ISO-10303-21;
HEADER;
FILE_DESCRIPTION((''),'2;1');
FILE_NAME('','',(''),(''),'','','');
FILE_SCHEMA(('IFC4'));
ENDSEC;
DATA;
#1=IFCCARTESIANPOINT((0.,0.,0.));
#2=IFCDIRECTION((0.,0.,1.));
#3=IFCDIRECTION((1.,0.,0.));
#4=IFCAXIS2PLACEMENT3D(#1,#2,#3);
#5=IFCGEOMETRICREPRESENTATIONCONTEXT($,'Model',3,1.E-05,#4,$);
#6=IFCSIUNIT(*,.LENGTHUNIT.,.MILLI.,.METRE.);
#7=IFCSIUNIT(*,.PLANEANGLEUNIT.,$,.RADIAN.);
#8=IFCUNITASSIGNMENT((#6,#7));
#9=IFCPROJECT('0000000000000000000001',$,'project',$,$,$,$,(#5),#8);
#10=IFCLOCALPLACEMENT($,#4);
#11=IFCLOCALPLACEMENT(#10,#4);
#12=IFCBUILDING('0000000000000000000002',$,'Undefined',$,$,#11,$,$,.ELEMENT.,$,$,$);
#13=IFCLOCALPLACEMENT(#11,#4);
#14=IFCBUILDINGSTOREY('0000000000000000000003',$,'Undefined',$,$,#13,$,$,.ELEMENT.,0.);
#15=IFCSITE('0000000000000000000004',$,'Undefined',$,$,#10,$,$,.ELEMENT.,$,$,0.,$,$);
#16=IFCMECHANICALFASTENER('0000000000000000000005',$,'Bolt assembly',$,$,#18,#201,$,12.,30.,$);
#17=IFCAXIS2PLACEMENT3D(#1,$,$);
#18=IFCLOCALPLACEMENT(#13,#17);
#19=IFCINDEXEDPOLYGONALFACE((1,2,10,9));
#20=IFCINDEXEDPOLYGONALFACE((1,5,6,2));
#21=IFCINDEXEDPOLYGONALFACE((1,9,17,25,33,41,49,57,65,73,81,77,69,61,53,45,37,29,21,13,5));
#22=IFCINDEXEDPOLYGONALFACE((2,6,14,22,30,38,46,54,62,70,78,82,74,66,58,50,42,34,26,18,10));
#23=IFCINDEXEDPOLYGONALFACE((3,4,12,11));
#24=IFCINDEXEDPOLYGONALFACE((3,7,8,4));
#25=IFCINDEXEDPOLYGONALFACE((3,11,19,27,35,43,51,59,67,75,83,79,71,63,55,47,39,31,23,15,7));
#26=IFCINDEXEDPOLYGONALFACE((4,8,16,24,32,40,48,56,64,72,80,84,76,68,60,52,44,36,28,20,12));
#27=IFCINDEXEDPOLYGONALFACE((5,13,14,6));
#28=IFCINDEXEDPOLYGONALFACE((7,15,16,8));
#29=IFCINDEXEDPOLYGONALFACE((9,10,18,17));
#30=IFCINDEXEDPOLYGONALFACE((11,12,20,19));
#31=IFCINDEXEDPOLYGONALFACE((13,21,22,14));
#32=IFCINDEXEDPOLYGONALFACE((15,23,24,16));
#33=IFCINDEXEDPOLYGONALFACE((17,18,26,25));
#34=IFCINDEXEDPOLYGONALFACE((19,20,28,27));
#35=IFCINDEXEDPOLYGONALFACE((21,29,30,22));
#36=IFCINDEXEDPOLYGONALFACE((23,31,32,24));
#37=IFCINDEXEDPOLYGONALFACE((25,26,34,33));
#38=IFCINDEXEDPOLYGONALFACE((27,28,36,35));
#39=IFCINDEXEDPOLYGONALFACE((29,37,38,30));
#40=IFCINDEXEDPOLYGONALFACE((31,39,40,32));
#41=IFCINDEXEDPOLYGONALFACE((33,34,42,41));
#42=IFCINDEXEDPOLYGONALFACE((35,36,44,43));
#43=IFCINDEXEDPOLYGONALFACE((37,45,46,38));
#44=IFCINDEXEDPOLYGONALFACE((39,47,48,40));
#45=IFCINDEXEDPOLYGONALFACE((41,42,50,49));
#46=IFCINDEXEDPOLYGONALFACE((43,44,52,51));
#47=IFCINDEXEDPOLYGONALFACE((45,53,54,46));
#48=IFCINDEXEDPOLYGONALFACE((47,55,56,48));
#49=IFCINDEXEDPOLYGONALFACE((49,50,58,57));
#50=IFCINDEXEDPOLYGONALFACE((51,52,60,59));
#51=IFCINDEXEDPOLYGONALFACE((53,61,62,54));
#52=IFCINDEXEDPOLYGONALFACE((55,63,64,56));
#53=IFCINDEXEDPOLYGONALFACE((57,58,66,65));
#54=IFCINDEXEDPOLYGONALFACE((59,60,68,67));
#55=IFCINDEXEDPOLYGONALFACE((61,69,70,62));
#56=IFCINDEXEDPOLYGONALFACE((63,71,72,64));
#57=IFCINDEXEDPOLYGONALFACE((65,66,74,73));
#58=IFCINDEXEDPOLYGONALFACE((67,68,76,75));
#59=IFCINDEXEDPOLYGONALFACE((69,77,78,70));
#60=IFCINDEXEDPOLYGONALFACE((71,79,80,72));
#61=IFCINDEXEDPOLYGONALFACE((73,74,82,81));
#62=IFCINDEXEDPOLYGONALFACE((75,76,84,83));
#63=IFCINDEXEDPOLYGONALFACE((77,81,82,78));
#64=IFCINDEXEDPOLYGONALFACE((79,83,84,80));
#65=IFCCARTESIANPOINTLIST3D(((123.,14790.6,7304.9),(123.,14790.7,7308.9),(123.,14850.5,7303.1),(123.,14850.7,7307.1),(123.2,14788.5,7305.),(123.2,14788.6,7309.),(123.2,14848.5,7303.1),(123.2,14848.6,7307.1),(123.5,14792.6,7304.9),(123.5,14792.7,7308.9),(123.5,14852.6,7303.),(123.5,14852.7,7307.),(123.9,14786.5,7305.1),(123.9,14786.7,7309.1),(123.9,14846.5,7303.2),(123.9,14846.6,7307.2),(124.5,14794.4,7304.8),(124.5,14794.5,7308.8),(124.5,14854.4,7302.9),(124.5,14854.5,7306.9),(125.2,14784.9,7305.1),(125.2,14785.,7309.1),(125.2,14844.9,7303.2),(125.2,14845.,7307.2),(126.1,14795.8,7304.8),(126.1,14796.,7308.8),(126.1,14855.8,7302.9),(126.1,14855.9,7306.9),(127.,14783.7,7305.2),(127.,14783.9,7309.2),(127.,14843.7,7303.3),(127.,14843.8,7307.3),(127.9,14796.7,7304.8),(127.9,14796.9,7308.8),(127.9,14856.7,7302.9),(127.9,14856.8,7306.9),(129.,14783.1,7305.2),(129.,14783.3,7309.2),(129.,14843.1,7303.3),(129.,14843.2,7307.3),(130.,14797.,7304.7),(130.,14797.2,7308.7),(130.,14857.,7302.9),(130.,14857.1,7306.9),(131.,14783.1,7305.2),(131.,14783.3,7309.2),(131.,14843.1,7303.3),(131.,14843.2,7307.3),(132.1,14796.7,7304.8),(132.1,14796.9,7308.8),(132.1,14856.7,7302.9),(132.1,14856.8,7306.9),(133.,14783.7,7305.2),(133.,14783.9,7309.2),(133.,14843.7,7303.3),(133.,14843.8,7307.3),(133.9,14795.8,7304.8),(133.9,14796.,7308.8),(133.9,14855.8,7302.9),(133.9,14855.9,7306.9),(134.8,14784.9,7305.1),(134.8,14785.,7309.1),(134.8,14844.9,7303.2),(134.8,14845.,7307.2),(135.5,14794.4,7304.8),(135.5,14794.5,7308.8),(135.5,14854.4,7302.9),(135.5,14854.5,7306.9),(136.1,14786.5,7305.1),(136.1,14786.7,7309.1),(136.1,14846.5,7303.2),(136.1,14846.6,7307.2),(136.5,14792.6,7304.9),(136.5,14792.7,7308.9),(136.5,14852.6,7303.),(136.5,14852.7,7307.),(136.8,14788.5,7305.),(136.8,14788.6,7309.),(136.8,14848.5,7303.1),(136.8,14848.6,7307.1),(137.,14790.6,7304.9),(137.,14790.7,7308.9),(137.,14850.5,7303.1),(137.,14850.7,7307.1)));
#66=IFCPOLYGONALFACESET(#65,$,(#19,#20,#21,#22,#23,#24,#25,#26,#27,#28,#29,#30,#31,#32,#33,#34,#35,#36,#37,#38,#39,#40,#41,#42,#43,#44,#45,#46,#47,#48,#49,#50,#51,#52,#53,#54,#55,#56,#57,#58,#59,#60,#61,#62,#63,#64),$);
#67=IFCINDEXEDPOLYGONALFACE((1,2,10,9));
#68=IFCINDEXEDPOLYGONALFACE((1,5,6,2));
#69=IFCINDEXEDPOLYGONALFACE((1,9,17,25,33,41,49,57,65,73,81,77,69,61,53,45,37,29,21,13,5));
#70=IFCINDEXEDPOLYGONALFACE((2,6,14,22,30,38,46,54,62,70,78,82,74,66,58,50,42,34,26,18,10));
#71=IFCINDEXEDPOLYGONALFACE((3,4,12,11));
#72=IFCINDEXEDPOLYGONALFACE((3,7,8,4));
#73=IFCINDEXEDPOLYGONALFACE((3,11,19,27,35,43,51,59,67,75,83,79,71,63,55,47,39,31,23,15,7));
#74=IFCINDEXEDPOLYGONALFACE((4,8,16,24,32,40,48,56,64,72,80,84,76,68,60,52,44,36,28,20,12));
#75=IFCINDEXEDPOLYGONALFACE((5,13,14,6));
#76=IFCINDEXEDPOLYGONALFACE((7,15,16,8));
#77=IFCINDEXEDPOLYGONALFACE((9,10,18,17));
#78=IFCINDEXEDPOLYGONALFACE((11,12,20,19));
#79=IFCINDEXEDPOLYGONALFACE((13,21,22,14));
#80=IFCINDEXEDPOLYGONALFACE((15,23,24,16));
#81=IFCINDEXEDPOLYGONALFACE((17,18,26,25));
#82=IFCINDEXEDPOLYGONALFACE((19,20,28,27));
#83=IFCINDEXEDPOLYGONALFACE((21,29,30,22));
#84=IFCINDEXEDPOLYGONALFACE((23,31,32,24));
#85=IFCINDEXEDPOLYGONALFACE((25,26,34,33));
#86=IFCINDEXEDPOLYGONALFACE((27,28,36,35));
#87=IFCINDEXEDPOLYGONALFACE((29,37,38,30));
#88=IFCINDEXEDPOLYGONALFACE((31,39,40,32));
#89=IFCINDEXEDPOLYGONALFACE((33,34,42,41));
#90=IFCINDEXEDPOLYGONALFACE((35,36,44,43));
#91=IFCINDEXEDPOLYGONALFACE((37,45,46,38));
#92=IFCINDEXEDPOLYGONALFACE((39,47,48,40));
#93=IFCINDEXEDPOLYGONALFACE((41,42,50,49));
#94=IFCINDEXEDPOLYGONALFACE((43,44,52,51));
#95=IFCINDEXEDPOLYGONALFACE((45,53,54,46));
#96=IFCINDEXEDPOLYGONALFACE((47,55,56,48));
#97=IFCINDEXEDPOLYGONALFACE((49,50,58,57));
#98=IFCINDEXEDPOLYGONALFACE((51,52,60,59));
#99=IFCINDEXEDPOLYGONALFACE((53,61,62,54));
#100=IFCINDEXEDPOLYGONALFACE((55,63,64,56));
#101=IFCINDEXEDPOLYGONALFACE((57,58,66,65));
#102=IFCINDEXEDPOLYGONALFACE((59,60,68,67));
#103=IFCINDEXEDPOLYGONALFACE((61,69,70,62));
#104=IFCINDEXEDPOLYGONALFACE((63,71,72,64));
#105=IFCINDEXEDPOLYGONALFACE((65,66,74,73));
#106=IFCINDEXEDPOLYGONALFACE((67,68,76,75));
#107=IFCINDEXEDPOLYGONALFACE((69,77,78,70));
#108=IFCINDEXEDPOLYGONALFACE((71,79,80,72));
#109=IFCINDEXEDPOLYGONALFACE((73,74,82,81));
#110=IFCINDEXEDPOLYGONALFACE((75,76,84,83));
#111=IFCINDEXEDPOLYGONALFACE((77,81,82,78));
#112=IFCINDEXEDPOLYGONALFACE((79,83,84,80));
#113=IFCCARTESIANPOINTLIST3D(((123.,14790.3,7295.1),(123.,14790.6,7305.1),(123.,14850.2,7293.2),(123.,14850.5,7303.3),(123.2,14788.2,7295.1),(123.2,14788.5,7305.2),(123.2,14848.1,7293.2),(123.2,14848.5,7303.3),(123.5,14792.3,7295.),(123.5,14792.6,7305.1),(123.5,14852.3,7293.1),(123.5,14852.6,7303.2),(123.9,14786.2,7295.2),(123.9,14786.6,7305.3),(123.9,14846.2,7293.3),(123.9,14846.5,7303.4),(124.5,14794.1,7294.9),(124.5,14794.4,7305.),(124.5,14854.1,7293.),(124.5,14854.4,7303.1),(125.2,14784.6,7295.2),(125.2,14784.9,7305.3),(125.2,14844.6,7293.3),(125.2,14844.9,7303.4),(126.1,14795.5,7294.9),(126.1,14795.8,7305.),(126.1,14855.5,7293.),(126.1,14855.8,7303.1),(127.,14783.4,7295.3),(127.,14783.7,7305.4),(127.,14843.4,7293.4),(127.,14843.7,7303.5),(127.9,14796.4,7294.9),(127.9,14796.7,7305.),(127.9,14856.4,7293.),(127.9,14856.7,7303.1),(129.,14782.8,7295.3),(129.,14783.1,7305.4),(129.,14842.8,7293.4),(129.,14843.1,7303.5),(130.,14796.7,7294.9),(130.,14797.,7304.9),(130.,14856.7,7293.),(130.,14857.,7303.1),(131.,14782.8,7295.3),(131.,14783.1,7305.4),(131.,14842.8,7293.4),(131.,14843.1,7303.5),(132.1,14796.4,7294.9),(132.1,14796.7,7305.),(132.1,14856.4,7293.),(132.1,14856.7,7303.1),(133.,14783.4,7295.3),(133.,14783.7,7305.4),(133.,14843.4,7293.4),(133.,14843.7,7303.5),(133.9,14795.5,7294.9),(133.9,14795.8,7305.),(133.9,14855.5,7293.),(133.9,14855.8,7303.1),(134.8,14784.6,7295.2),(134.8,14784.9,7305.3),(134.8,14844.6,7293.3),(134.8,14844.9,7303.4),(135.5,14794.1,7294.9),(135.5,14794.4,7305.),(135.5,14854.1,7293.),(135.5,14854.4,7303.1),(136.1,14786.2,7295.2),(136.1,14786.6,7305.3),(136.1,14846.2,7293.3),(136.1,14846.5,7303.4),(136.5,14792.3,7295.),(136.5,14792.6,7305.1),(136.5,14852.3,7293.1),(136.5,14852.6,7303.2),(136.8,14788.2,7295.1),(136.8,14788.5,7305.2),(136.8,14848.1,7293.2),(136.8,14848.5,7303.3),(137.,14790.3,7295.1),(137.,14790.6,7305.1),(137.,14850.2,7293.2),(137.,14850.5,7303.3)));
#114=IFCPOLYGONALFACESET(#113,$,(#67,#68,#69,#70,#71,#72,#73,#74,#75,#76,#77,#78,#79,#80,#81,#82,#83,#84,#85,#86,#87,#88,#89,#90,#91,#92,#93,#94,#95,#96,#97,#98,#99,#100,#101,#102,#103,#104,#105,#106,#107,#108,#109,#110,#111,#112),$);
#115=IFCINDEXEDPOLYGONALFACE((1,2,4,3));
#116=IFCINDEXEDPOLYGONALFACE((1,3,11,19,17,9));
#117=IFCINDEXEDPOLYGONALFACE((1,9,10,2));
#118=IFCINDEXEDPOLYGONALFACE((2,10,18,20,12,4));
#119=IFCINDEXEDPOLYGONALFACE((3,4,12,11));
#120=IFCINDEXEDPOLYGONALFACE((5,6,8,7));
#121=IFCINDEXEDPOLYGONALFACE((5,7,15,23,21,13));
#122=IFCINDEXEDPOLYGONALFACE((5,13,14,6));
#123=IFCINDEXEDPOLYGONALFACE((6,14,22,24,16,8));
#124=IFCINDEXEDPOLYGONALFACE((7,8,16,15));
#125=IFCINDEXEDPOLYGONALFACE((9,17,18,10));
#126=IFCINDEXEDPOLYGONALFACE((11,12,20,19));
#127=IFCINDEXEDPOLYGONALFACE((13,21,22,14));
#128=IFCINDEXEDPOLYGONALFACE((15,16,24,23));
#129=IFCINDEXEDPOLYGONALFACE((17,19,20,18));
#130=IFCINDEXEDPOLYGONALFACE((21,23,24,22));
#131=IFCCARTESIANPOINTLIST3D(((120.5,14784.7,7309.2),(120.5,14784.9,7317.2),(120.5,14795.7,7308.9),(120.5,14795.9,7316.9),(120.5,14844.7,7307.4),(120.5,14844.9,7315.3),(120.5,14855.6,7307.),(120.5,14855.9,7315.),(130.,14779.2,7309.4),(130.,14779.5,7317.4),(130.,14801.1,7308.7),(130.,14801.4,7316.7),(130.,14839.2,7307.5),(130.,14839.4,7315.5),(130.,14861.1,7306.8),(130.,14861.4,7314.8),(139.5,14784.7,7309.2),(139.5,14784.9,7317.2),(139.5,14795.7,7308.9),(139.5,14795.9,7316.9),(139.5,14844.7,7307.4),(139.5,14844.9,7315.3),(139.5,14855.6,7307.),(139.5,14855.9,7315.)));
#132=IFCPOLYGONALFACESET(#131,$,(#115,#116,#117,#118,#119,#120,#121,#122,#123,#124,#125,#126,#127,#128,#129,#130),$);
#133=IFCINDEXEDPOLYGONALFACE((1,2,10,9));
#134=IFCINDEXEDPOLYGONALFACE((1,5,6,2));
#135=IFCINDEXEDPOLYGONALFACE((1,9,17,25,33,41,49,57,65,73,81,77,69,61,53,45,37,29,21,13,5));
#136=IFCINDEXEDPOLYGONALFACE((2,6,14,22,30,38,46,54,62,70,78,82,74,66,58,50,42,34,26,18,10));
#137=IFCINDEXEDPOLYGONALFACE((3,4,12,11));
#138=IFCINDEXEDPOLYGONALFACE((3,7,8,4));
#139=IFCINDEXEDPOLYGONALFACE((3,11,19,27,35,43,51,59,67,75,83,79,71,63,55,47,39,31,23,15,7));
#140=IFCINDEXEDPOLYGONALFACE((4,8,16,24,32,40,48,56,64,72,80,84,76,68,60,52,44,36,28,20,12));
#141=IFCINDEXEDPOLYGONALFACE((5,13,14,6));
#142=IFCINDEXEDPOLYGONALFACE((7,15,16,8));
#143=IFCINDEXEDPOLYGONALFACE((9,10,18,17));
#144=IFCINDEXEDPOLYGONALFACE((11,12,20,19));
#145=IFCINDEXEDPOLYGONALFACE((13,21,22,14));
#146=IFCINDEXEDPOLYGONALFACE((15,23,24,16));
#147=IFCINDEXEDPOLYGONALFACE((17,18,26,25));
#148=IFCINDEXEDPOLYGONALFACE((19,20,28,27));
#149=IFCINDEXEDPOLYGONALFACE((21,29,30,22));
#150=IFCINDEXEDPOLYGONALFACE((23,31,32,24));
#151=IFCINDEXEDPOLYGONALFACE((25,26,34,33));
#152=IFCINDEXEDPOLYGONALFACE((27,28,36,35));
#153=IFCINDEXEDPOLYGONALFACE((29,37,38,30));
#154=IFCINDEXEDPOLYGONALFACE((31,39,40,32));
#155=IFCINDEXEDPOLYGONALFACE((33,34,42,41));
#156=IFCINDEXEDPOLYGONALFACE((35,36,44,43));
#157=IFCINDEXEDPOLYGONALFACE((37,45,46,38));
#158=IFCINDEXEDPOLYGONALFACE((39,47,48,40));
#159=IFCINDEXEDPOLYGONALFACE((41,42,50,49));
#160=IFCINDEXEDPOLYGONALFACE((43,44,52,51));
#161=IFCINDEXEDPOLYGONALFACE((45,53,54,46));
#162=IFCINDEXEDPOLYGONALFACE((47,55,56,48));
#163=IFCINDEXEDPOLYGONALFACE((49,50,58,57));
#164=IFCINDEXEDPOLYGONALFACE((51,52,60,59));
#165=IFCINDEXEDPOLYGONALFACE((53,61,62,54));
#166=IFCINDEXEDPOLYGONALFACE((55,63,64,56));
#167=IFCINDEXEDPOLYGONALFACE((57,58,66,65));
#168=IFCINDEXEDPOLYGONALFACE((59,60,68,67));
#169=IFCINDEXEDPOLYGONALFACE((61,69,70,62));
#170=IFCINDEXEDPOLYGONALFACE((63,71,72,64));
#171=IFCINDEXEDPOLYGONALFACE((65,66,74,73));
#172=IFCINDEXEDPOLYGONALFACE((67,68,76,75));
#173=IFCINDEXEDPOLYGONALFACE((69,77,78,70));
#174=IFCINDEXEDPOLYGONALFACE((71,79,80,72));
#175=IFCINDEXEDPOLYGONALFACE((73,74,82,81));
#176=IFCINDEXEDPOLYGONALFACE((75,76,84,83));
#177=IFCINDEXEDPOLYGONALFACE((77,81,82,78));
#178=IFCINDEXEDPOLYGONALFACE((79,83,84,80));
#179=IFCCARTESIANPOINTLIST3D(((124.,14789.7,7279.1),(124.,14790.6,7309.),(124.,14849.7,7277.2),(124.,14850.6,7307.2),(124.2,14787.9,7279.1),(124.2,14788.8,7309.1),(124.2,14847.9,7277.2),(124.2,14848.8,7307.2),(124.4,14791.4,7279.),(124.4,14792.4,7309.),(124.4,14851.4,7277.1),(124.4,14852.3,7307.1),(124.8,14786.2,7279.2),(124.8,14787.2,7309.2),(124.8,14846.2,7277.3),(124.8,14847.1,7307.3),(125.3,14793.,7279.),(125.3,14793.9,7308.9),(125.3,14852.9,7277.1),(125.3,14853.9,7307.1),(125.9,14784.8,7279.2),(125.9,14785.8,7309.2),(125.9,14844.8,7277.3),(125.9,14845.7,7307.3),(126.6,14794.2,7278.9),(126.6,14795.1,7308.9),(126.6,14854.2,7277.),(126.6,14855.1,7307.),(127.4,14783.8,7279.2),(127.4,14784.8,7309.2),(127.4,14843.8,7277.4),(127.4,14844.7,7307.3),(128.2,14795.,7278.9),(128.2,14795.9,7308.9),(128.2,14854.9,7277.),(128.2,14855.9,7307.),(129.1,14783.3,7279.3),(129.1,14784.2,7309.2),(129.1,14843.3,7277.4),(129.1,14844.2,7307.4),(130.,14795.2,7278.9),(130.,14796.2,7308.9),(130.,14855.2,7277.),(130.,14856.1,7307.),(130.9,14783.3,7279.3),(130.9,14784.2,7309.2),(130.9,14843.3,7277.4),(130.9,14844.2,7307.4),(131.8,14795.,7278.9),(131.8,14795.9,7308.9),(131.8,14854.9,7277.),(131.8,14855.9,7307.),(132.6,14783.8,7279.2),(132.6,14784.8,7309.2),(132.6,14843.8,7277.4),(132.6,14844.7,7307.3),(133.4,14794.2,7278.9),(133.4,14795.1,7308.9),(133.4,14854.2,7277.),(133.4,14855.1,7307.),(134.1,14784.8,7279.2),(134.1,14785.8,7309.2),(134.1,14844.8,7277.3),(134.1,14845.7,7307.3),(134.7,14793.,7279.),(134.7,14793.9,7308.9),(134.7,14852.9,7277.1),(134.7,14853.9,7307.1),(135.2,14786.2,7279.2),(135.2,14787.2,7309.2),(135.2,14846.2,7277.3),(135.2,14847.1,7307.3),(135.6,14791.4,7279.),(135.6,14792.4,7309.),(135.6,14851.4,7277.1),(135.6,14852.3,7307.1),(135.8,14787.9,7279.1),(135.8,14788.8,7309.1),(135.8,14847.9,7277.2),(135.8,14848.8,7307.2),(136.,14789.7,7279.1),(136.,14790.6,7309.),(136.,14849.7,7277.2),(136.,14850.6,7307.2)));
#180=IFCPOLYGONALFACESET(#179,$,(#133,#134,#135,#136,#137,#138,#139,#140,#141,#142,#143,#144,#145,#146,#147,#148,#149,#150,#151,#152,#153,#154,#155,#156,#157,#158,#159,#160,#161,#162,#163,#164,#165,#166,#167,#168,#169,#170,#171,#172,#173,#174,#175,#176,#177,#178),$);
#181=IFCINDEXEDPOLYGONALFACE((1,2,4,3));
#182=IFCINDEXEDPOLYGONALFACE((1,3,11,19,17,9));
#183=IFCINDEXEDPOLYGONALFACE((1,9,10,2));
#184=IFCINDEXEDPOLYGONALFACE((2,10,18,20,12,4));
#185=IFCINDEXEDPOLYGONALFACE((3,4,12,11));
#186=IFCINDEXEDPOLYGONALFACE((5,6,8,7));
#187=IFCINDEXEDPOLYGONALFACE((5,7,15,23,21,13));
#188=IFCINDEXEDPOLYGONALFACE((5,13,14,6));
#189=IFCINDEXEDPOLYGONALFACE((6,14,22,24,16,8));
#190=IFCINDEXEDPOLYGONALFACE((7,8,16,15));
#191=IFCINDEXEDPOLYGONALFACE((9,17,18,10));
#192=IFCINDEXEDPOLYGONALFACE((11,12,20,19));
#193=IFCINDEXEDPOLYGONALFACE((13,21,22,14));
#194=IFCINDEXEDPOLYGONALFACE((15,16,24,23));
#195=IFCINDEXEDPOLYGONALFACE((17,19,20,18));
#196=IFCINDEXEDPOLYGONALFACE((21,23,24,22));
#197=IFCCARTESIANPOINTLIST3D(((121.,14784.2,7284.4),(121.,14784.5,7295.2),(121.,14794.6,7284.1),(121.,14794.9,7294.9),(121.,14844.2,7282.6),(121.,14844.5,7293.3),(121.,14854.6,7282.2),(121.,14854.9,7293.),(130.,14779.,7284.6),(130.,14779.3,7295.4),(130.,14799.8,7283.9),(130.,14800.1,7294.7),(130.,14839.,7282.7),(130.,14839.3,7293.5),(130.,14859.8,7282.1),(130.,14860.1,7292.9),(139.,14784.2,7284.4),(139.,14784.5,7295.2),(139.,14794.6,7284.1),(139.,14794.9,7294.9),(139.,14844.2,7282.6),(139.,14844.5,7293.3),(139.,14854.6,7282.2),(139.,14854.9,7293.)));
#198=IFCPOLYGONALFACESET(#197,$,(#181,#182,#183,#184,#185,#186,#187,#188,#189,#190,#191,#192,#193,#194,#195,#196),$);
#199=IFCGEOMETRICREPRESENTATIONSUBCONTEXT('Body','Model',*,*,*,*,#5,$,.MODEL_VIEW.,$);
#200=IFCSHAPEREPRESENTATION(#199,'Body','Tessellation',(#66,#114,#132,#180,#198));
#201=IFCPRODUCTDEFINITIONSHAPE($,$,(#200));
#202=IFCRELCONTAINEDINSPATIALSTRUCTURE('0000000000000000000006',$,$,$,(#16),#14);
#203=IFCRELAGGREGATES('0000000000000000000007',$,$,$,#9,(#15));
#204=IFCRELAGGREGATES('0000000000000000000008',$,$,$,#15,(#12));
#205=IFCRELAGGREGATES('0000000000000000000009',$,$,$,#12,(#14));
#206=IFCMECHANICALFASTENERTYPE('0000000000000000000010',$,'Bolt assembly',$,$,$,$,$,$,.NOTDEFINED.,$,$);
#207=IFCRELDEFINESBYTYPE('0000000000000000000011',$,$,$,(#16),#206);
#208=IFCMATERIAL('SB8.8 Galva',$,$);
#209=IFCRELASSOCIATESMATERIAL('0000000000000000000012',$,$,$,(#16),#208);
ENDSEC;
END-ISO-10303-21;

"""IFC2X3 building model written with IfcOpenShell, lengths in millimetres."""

from ifc_helpers import new_model, si_unit, frame, origin_with_axes, origin_2d_with_axis, place, context, subcontext, project, spatial, polyline, circle, outline, extrude, source, transform, mapped, material, type_object, element, save


model = new_model("IFC2X3")

# Units and contexts
model_context = context("Model", 3, precision=1e-05, world=origin_with_axes())
body_context = subcontext(model_context, "Body", "Model", "MODEL_VIEW")
ifc_project = project(units=[si_unit("LENGTHUNIT", "METRE", prefix="MILLI"), si_unit("PLANEANGLEUNIT", "RADIAN")], contexts=[model_context])

# Site, building, storey
site_placement = place(None, origin_with_axes())
site = spatial("IfcSite", under=ifc_project, at=site_placement, Name="Undefined", CompositionType="ELEMENT", RefElevation=0.0)
building_placement = place(site_placement, origin_with_axes())
building = spatial("IfcBuilding", under=site, at=building_placement, Name="Undefined", CompositionType="ELEMENT")
storey_placement = place(building_placement, origin_with_axes())
storey = spatial("IfcBuildingStorey", under=building, at=storey_placement, Name="Undefined", CompositionType="ELEMENT", Elevation=0.0)

# Mechanical fastener
mechanical_fastener_type = type_object("IfcMechanicalFastenerType", Name="Bolt assembly")
ifc_material_1 = material(Name="SB8.8 Galva")
shared_shape_1 = source(origin_with_axes(), body_context, "Body", "SweptSolid", [
    extrude(circle(Radius=7.0, at=origin_2d_with_axis()), frame((0.0, -3.9, 0.0), z_axis=(0.0, 1.0, 0.0), x_axis=(1.0, 0.0, 0.0)), (0.0, 0.0, 1.0), 4.0),
    extrude(circle(Radius=7.0, at=origin_2d_with_axis()), frame((0.0, -0.1, 0.0), z_axis=(0.0, 1.0, 0.0), x_axis=(1.0, 0.0, 0.0)), (0.0, 0.0, 1.0), 10.1),
    extrude(outline(polyline([(11.0, 0.0), (5.5, 9.5), (-5.5, 9.5), (-11.0, 0.0), (-5.5, -9.5), (5.5, -9.5), (11.0, 0.0)])), frame((0.0, -12.0, 0.0), z_axis=(0.0, 1.0, 0.0), x_axis=(1.0, 0.0, 0.0)), (0.0, 0.0, 1.0), 8.0),
    extrude(circle(Radius=6.0, at=origin_2d_with_axis()), frame((0.0, -4.0, 0.0), z_axis=(0.0, 1.0, 0.0), x_axis=(1.0, 0.0, 0.0)), (0.0, 0.0, 1.0), 30.0),
    extrude(outline(polyline([(10.4, 0.0), (5.2, 9.0), (-5.2, 9.0), (-10.4, 0.0), (-5.2, -9.0), (5.2, -9.0), (10.4, 0.0)])), frame((0.0, 10.0, 0.0), z_axis=(0.0, 1.0, 0.0), x_axis=(1.0, 0.0, 0.0)), (0.0, 0.0, 1.0), 10.8),
])
mechanical_fastener_1_placement = place(storey_placement, frame((130.0, 14790.0, 7305.1), z_axis=(-1.0, 0.0, 0.0), x_axis=(0.0, 0.999507, -0.031411)))
element("IfcMechanicalFastener", 1, at=mechanical_fastener_1_placement, inside=storey, type_object=mechanical_fastener_type, material=ifc_material_1, Name="Bolt assembly", NominalDiameter=12.0, NominalLength=30.0, context=body_context, shape_type="MappedRepresentation", body=[
    mapped(shared_shape_1, transform((0.0, 0.0, 0.0))),
    mapped(shared_shape_1, transform((60.0, 0.0, 0.0))),
])

save(model, "model.ifc")
